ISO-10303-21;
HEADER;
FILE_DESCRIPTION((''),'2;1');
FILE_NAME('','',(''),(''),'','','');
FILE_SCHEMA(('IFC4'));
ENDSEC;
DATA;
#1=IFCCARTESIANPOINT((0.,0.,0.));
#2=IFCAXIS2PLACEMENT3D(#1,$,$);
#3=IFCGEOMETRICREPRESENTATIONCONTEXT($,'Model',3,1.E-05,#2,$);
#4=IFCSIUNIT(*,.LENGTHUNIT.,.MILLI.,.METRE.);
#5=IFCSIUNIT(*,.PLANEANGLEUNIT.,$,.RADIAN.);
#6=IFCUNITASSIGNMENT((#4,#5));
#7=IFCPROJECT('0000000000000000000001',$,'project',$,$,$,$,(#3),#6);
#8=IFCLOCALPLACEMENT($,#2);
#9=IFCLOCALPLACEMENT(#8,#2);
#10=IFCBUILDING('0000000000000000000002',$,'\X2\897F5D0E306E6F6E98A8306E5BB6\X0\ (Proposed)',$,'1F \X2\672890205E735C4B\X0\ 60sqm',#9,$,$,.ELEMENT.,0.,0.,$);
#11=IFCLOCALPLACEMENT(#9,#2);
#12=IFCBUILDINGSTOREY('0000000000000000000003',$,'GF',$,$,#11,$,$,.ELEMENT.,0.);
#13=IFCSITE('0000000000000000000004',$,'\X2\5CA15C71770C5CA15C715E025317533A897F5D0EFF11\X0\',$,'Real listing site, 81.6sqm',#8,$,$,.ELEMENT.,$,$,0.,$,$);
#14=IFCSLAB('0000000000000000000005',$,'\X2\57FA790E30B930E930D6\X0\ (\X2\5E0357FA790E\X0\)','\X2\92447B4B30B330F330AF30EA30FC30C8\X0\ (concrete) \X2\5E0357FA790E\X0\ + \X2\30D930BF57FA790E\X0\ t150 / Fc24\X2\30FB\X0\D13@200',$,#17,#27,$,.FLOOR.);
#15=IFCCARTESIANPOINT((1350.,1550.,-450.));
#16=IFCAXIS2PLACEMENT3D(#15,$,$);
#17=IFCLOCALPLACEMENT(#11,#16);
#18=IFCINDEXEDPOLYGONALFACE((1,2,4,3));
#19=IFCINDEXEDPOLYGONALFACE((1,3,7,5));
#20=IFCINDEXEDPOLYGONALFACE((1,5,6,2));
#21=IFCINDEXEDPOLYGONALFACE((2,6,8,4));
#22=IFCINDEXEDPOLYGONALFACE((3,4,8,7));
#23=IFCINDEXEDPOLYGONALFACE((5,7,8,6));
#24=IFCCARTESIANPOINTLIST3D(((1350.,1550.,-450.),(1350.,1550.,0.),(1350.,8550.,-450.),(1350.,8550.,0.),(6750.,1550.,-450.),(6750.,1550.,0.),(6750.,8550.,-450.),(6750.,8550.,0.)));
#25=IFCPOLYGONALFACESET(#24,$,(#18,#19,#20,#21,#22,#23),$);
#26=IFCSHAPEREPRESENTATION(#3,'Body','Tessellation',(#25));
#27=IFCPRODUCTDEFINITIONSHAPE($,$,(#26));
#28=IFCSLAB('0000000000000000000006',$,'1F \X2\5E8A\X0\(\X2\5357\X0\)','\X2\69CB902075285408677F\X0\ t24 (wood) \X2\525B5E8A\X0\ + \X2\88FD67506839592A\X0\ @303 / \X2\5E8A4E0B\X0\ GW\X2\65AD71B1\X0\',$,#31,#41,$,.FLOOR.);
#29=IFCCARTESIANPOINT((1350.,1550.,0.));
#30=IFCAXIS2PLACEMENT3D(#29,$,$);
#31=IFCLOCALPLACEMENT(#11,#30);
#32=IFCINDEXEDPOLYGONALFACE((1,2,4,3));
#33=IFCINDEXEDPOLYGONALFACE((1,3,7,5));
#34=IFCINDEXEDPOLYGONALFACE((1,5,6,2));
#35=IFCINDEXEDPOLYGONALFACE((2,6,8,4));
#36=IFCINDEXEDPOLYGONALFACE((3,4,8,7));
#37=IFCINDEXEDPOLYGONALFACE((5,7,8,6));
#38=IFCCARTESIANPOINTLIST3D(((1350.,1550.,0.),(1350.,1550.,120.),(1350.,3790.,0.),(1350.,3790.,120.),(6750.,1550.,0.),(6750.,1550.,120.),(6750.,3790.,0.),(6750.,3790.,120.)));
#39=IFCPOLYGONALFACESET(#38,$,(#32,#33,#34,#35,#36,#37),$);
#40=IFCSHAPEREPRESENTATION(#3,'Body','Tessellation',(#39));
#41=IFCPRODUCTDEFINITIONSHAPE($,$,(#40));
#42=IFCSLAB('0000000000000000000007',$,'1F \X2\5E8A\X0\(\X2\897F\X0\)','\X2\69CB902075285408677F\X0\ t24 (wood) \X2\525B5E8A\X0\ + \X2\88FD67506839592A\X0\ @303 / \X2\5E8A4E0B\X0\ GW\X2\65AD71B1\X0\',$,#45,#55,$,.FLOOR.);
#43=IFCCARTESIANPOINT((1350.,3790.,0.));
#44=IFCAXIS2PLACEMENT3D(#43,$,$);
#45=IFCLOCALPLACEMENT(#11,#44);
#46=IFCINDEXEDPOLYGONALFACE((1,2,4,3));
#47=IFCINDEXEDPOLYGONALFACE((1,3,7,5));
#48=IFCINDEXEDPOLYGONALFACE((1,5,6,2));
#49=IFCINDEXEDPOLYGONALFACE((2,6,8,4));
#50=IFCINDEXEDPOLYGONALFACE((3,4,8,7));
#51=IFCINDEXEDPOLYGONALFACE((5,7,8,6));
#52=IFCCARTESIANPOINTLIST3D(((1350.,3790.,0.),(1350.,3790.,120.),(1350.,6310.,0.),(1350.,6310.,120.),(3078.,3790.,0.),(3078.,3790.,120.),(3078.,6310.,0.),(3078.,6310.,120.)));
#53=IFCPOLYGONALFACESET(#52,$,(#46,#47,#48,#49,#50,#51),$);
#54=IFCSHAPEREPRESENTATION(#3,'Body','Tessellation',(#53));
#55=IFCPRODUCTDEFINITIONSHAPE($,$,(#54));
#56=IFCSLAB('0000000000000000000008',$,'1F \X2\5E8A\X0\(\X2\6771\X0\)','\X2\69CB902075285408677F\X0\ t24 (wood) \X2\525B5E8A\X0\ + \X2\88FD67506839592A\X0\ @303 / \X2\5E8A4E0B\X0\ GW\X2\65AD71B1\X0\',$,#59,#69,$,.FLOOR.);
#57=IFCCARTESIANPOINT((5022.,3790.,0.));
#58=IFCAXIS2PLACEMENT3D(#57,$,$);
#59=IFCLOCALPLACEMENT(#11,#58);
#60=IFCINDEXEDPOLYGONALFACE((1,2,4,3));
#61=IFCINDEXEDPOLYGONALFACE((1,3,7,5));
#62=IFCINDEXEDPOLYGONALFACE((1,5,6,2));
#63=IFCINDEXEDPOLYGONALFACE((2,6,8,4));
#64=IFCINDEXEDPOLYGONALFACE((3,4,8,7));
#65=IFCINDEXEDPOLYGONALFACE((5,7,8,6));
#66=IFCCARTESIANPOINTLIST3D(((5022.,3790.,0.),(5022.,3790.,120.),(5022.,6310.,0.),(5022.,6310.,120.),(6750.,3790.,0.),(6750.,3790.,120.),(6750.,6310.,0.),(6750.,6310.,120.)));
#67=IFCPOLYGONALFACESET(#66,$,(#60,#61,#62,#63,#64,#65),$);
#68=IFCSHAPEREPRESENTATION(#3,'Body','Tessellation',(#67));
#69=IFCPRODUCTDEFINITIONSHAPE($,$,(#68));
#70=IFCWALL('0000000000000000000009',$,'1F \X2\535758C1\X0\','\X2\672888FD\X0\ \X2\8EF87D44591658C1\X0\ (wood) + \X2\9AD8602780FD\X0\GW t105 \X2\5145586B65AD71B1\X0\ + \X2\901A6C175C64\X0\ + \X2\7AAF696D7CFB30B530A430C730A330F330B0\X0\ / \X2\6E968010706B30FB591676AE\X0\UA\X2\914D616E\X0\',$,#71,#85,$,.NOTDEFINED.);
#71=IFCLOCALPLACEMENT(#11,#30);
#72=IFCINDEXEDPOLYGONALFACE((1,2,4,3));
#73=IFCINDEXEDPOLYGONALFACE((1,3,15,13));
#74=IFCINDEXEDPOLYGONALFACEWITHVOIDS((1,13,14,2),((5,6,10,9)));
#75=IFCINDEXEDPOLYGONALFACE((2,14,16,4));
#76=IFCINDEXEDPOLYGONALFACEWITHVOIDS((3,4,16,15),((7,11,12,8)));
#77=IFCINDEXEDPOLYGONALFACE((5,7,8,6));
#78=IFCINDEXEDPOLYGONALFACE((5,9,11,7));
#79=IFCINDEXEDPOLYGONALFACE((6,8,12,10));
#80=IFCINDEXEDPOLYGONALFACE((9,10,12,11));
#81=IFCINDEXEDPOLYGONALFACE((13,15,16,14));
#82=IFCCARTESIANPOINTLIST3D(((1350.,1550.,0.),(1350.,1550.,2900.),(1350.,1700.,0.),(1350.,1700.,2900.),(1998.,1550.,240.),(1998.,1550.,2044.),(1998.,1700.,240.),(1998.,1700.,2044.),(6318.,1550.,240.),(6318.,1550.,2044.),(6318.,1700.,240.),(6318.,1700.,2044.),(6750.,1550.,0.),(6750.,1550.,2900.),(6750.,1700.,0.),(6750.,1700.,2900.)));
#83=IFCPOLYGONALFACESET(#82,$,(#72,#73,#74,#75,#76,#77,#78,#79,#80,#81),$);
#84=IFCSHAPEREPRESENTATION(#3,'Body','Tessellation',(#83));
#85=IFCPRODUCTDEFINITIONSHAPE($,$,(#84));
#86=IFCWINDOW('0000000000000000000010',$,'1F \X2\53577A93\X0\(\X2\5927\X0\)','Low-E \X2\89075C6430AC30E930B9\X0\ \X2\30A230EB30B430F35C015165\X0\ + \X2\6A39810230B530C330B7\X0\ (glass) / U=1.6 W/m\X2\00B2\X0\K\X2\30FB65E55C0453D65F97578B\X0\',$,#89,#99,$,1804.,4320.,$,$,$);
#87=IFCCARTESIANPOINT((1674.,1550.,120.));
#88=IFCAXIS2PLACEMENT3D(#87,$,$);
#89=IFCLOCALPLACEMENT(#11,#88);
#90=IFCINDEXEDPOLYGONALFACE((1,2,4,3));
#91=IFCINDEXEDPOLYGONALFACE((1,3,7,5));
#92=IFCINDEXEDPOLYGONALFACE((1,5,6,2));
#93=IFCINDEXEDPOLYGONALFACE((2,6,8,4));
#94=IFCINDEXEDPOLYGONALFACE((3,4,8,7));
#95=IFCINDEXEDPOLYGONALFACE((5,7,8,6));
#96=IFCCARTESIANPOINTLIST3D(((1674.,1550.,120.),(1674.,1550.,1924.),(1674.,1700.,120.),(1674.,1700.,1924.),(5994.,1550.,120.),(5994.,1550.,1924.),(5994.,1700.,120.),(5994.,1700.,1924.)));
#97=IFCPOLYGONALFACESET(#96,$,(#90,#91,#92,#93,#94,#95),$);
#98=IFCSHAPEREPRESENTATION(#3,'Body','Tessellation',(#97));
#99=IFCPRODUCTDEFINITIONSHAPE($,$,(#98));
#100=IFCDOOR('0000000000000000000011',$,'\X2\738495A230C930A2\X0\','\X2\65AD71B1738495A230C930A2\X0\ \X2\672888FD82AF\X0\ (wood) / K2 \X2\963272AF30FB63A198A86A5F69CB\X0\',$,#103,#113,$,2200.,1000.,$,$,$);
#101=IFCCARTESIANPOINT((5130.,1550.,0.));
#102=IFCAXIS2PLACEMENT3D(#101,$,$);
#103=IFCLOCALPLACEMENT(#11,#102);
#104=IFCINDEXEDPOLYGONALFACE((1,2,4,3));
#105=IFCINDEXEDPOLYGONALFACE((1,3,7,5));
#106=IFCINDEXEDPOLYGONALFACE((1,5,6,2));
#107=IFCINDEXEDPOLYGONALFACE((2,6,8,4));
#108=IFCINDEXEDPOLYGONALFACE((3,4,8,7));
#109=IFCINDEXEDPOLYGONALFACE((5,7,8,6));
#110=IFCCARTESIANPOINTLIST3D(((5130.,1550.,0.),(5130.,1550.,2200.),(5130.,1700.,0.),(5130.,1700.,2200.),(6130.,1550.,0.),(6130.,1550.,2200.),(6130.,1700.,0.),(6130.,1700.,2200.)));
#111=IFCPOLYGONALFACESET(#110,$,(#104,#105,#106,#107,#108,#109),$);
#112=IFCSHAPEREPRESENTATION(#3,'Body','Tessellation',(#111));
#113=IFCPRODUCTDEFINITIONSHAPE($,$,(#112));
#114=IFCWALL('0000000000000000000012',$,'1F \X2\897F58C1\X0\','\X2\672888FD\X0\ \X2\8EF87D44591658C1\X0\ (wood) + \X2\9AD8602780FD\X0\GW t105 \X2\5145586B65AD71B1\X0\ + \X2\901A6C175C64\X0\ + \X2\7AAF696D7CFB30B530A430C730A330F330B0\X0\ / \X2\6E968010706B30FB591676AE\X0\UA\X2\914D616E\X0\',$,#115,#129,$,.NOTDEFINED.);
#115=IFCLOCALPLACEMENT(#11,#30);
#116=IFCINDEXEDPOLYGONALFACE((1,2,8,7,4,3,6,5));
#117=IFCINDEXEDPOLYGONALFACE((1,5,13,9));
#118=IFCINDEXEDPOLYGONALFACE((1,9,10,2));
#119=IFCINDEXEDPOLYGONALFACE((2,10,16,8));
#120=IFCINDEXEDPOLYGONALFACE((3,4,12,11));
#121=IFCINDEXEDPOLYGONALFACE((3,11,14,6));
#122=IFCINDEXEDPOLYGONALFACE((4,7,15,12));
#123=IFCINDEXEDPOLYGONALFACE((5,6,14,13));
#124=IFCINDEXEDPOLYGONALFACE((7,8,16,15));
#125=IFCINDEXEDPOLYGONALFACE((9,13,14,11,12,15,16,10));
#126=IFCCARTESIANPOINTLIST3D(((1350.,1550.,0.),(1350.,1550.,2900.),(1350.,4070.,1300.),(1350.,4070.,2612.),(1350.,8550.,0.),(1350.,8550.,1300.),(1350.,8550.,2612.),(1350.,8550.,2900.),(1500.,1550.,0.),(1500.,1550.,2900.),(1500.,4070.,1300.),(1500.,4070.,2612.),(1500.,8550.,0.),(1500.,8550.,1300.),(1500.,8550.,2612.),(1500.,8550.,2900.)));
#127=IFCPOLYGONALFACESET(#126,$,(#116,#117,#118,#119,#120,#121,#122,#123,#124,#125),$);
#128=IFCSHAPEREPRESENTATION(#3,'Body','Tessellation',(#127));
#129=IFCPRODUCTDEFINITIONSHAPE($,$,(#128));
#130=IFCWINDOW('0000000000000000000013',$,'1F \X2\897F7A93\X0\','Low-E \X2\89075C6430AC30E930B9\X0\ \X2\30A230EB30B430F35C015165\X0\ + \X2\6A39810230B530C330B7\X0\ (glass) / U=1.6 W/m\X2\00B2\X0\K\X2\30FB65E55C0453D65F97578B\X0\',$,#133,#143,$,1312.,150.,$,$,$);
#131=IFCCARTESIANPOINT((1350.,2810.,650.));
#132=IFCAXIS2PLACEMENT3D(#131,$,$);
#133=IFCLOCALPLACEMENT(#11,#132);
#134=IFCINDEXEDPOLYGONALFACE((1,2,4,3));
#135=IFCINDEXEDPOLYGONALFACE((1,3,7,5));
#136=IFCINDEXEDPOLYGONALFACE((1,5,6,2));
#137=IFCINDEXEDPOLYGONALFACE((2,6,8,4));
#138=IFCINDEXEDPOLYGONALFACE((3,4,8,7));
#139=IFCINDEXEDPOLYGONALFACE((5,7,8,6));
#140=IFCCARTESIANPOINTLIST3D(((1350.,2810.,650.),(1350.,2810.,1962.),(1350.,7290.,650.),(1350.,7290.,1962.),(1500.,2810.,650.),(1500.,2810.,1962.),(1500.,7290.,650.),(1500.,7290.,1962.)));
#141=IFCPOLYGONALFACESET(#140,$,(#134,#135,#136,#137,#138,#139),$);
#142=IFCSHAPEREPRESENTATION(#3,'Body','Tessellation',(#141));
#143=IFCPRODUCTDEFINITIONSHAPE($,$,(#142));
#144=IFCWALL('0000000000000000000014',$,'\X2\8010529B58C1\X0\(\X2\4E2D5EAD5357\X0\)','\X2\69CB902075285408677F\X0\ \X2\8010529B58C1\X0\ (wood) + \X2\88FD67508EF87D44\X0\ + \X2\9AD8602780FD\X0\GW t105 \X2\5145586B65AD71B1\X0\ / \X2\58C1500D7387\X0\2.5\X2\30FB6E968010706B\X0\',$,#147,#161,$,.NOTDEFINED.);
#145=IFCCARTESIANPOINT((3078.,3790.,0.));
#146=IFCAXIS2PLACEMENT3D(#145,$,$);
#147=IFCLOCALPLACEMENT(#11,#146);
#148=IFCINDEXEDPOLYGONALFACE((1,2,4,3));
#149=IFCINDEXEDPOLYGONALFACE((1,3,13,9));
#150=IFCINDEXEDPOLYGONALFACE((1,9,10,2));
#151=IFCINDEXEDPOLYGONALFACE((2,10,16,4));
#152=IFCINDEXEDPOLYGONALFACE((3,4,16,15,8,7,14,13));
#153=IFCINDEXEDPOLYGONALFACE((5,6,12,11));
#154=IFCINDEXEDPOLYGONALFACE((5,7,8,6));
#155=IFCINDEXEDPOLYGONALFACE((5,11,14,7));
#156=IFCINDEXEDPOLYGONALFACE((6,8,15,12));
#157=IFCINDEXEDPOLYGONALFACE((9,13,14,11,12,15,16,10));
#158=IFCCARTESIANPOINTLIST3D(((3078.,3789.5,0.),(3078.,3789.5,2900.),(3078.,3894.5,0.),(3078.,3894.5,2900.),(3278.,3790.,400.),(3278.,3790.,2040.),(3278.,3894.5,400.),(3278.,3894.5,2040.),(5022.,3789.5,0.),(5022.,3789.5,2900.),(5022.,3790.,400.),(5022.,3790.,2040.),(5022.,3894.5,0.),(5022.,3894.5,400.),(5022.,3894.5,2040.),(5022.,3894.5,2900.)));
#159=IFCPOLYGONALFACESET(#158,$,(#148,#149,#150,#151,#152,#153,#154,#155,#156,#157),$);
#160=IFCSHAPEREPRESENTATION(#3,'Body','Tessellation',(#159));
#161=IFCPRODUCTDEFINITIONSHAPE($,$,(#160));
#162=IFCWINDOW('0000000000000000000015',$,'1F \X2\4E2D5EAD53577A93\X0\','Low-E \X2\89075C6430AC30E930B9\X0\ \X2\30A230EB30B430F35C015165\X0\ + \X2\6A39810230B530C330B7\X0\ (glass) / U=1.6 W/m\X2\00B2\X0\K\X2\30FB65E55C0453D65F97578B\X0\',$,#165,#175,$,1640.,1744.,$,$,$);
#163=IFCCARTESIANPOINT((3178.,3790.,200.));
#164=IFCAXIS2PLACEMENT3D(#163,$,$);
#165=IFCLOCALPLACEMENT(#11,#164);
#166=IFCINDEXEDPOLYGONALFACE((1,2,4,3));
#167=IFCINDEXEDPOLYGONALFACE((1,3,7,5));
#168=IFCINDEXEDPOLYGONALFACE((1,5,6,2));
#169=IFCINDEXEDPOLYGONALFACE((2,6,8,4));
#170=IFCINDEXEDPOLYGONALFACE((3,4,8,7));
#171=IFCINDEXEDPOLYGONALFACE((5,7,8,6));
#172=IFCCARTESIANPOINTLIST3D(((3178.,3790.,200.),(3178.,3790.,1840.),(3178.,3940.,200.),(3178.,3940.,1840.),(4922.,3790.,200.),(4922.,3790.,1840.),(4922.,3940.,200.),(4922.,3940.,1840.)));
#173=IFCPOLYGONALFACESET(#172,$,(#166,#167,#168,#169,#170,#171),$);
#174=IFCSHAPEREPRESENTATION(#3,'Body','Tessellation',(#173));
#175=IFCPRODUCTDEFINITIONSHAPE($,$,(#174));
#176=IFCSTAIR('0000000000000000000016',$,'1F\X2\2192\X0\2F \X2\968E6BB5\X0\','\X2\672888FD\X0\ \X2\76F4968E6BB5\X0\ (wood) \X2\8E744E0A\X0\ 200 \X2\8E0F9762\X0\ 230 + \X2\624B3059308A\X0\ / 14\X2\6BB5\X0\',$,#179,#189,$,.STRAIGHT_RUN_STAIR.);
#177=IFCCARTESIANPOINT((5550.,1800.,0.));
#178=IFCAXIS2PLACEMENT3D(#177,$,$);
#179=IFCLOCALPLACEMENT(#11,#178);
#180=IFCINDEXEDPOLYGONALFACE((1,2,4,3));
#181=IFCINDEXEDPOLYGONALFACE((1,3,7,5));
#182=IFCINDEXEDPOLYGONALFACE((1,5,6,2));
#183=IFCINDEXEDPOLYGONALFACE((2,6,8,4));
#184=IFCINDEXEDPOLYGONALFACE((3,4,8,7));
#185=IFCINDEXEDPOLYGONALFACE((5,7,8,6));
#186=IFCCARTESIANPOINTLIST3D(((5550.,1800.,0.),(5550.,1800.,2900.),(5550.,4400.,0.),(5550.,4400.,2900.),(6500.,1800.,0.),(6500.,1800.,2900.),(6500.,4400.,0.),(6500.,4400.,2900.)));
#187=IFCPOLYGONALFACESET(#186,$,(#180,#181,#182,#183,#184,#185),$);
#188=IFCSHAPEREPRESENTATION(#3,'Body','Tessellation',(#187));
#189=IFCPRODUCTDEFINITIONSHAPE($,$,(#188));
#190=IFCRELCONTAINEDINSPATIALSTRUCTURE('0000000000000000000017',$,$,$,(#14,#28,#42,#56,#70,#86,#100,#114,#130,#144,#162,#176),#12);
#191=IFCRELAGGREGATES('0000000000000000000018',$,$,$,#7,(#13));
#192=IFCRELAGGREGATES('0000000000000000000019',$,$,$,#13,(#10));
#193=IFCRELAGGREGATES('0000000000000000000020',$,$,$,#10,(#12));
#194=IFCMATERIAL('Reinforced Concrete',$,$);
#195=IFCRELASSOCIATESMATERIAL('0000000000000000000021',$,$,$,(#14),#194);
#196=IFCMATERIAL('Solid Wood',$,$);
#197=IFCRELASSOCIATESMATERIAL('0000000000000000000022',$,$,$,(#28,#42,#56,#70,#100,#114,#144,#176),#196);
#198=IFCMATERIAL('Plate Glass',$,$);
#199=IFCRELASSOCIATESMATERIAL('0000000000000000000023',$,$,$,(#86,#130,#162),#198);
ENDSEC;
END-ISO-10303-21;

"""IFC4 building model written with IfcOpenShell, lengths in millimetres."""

from ifc_helpers import new_model, si_unit, frame, frame_2d, origin, place, context, project, spatial, rectangle, extrude, material, element, fill, save


model = new_model("IFC4")

# Units and contexts
model_context = context("Model", 3, precision=1e-05, world=origin())
ifc_project = project(units=[si_unit("LENGTHUNIT", "METRE", prefix="MILLI"), si_unit("PLANEANGLEUNIT", "RADIAN")], contexts=[model_context])

# Site, building, storey
site_placement = place(None, origin())
site = spatial("IfcSite", under=ifc_project, at=site_placement, Name="岡山県岡山市北区西崎１", ObjectType="Real listing site, 81.6sqm", CompositionType="ELEMENT", RefElevation=0.0)
building_placement = place(site_placement, origin())
building = spatial("IfcBuilding", under=site, at=building_placement, Name="西崎の潮風の家 (Proposed)", ObjectType="1F 木造平屋 60sqm", CompositionType="ELEMENT", ElevationOfRefHeight=0.0, ElevationOfTerrain=0.0)
storey_placement = place(building_placement, origin())
storey = spatial("IfcBuildingStorey", under=building, at=storey_placement, Name="GF", CompositionType="ELEMENT", Elevation=0.0)

# Slabs
ifc_material_1 = material(Name="Reinforced Concrete")
slab_1_placement = place(storey_placement, frame((1350.0, 1550.0, -450.0)))
element("IfcSlab", 1, at=slab_1_placement, inside=storey, material=ifc_material_1, Name="基礎スラブ (布基礎)", Description="鉄筋コンクリート (concrete) 布基礎 + ベタ基礎 t150 / Fc24・D13@200", PredefinedType="FLOOR", context=model_context, shape_type="SweptSolid", body=[
    extrude(rectangle(XDim=5400.0, YDim=7000.0, at=frame_2d((2700.0, 3500.0))), frame((1350.0, 1550.0, -450.0)), (0.0, 0.0, 1.0), 450.0),
])
ifc_material_2 = material(Name="Solid Wood")
slab_2_placement = place(storey_placement, frame((1350.0, 1550.0, 0.0)))
element("IfcSlab", 2, at=slab_2_placement, inside=storey, material=ifc_material_2, Name="1F 床(南)", Description="構造用合板 t24 (wood) 剛床 + 製材根太 @303 / 床下 GW断熱", PredefinedType="FLOOR", context=model_context, shape_type="SweptSolid", body=[
    extrude(rectangle(XDim=5400.0, YDim=2240.0, at=frame_2d((2700.0, 1120.0))), frame((1350.0, 1550.0, 0.0)), (0.0, 0.0, 1.0), 120.0),
])
slab_3_placement = place(storey_placement, frame((1350.0, 3790.0, 0.0)))
element("IfcSlab", 3, at=slab_3_placement, inside=storey, material=ifc_material_2, Name="1F 床(西)", Description="構造用合板 t24 (wood) 剛床 + 製材根太 @303 / 床下 GW断熱", PredefinedType="FLOOR", context=model_context, shape_type="SweptSolid", body=[
    extrude(rectangle(XDim=1728.0, YDim=2520.0, at=frame_2d((864.0, 1260.0))), frame((1350.0, 3790.0, 0.0)), (0.0, 0.0, 1.0), 120.0),
])
slab_4_placement = place(storey_placement, frame((5022.0, 3790.0, 0.0)))
element("IfcSlab", 4, at=slab_4_placement, inside=storey, material=ifc_material_2, Name="1F 床(東)", Description="構造用合板 t24 (wood) 剛床 + 製材根太 @303 / 床下 GW断熱", PredefinedType="FLOOR", context=model_context, shape_type="SweptSolid", body=[
    extrude(rectangle(XDim=1728.0, YDim=2520.0, at=frame_2d((864.0, 1260.0))), frame((5022.0, 3790.0, 0.0)), (0.0, 0.0, 1.0), 120.0),
])

# Wall, openings, window, door
wall_1_placement = place(storey_placement, frame((1350.0, 1550.0, 0.0)))
wall_1 = element("IfcWall", 5, at=wall_1_placement, inside=storey, material=ifc_material_2, Name="1F 南壁", Description="木製 軸組外壁 (wood) + 高性能GW t105 充填断熱 + 通気層 + 窯業系サイディング / 準耐火・外皮UA配慮", PredefinedType="NOTDEFINED", context=model_context, shape_type="SweptSolid", body=[
    extrude(rectangle(XDim=5400.0, YDim=150.0, at=frame_2d((2700.0, 75.0))), frame((1350.0, 1550.0, 0.0)), (0.0, 0.0, 1.0), 2900.0),
])
opening_1_placement = place(storey_placement, frame((1674.0, 1550.0, 120.0)))
opening_1 = element("IfcOpeningElement", 6, at=opening_1_placement, cuts=wall_1, PredefinedType="NOTDEFINED", context=model_context, shape_type="SweptSolid", body=[
    extrude(rectangle(XDim=4320.0, YDim=150.0, at=frame_2d((2160.0, 75.0))), frame((1674.0, 1550.0, 120.0)), (0.0, 0.0, 1.0), 1804.0),
])
opening_2_placement = place(storey_placement, frame((5130.0, 1550.0, 0.0)))
opening_2 = element("IfcOpeningElement", 7, at=opening_2_placement, cuts=wall_1, PredefinedType="NOTDEFINED", context=model_context, shape_type="SweptSolid", body=[
    extrude(rectangle(XDim=1000.0, YDim=150.0, at=frame_2d((500.0, 75.0))), frame((5130.0, 1550.0, 0.0)), (0.0, 0.0, 1.0), 2200.0),
])
ifc_material_3 = material(Name="Plate Glass")
window_1_placement = place(storey_placement, frame((1674.0, 1550.0, 120.0)))
window_1 = element("IfcWindow", 8, at=window_1_placement, inside=storey, material=ifc_material_3, Name="1F 南窓(大)", Description="Low-E 複層ガラス アルゴン封入 + 樹脂サッシ (glass) / U=1.6 W/m²K・日射取得型", OverallHeight=1804.0, OverallWidth=4320.0, context=model_context, shape_type="SweptSolid", body=[
    extrude(rectangle(XDim=4320.0, YDim=150.0, at=frame_2d((2160.0, 75.0))), frame((1674.0, 1550.0, 120.0)), (0.0, 0.0, 1.0), 1804.0),
])
fill(opening_1, window_1)
door_placement = place(storey_placement, frame((5130.0, 1550.0, 0.0)))
door = element("IfcDoor", 9, at=door_placement, inside=storey, material=ifc_material_2, Name="玄関ドア", Description="断熱玄関ドア 木製芯 (wood) / K2 防犯・採風機構", OverallHeight=2200.0, OverallWidth=1000.0, context=model_context, shape_type="SweptSolid", body=[
    extrude(rectangle(XDim=1000.0, YDim=150.0, at=frame_2d((500.0, 75.0))), frame((5130.0, 1550.0, 0.0)), (0.0, 0.0, 1.0), 2200.0),
])
fill(opening_2, door)

# Walls, openings, windows
wall_2_placement = place(storey_placement, frame((1350.0, 1550.0, 0.0)))
wall_2 = element("IfcWall", 10, at=wall_2_placement, inside=storey, material=ifc_material_2, Name="1F 西壁", Description="木製 軸組外壁 (wood) + 高性能GW t105 充填断熱 + 通気層 + 窯業系サイディング / 準耐火・外皮UA配慮", PredefinedType="NOTDEFINED", context=model_context, shape_type="SweptSolid", body=[
    extrude(rectangle(XDim=150.0, YDim=7000.0, at=frame_2d((75.0, 3500.0))), frame((1350.0, 1550.0, 0.0)), (0.0, 0.0, 1.0), 2900.0),
])
opening_3_placement = place(storey_placement, frame((1350.0, 2810.0, 650.0)))
opening_3 = element("IfcOpeningElement", 11, at=opening_3_placement, cuts=wall_2, PredefinedType="NOTDEFINED", context=model_context, shape_type="SweptSolid", body=[
    extrude(rectangle(XDim=150.0, YDim=4480.0, at=frame_2d((75.0, 2240.0))), frame((1350.0, 2810.0, 650.0)), (0.0, 0.0, 1.0), 1312.0),
])
window_2_placement = place(storey_placement, frame((1350.0, 2810.0, 650.0)))
window_2 = element("IfcWindow", 12, at=window_2_placement, inside=storey, material=ifc_material_3, Name="1F 西窓", Description="Low-E 複層ガラス アルゴン封入 + 樹脂サッシ (glass) / U=1.6 W/m²K・日射取得型", OverallHeight=1312.0, OverallWidth=150.0, context=model_context, shape_type="SweptSolid", body=[
    extrude(rectangle(XDim=150.0, YDim=4480.0, at=frame_2d((75.0, 2240.0))), frame((1350.0, 2810.0, 650.0)), (0.0, 0.0, 1.0), 1312.0),
])
fill(opening_3, window_2)
wall_3_placement = place(storey_placement, frame((3078.0, 3790.0, 0.0)))
wall_3 = element("IfcWall", 13, at=wall_3_placement, inside=storey, material=ifc_material_2, Name="耐力壁(中庭南)", Description="構造用合板 耐力壁 (wood) + 製材軸組 + 高性能GW t105 充填断熱 / 壁倍率2.5・準耐火", PredefinedType="NOTDEFINED", context=model_context, shape_type="SweptSolid", body=[
    extrude(rectangle(XDim=1944.0, YDim=105.0, at=frame_2d((972.0, 52.0))), frame((3078.0, 3790.0, 0.0)), (0.0, 0.0, 1.0), 2900.0),
])
opening_4_placement = place(storey_placement, frame((3178.0, 3790.0, 200.0)))
opening_4 = element("IfcOpeningElement", 14, at=opening_4_placement, cuts=wall_3, PredefinedType="NOTDEFINED", context=model_context, shape_type="SweptSolid", body=[
    extrude(rectangle(XDim=1744.0, YDim=150.0, at=frame_2d((872.0, 75.0))), frame((3178.0, 3790.0, 200.0)), (0.0, 0.0, 1.0), 1640.0),
])
window_3_placement = place(storey_placement, frame((3178.0, 3790.0, 200.0)))
window_3 = element("IfcWindow", 15, at=window_3_placement, inside=storey, material=ifc_material_3, Name="1F 中庭南窓", Description="Low-E 複層ガラス アルゴン封入 + 樹脂サッシ (glass) / U=1.6 W/m²K・日射取得型", OverallHeight=1640.0, OverallWidth=1744.0, context=model_context, shape_type="SweptSolid", body=[
    extrude(rectangle(XDim=1744.0, YDim=150.0, at=frame_2d((872.0, 75.0))), frame((3178.0, 3790.0, 200.0)), (0.0, 0.0, 1.0), 1640.0),
])
fill(opening_4, window_3)

# Stair
stair_placement = place(storey_placement, frame((5550.0, 1800.0, 0.0)))
element("IfcStair", 16, at=stair_placement, inside=storey, material=ifc_material_2, Name="1F→2F 階段", Description="木製 直階段 (wood) 蹴上 200 踏面 230 + 手すり / 14段", PredefinedType="STRAIGHT_RUN_STAIR", context=model_context, shape_type="SweptSolid", body=[
    extrude(rectangle(XDim=950.0, YDim=2600.0, at=frame_2d((475.0, 1300.0))), frame((5550.0, 1800.0, 0.0)), (0.0, 0.0, 1.0), 2900.0),
])

save(model, "model.ifc")
